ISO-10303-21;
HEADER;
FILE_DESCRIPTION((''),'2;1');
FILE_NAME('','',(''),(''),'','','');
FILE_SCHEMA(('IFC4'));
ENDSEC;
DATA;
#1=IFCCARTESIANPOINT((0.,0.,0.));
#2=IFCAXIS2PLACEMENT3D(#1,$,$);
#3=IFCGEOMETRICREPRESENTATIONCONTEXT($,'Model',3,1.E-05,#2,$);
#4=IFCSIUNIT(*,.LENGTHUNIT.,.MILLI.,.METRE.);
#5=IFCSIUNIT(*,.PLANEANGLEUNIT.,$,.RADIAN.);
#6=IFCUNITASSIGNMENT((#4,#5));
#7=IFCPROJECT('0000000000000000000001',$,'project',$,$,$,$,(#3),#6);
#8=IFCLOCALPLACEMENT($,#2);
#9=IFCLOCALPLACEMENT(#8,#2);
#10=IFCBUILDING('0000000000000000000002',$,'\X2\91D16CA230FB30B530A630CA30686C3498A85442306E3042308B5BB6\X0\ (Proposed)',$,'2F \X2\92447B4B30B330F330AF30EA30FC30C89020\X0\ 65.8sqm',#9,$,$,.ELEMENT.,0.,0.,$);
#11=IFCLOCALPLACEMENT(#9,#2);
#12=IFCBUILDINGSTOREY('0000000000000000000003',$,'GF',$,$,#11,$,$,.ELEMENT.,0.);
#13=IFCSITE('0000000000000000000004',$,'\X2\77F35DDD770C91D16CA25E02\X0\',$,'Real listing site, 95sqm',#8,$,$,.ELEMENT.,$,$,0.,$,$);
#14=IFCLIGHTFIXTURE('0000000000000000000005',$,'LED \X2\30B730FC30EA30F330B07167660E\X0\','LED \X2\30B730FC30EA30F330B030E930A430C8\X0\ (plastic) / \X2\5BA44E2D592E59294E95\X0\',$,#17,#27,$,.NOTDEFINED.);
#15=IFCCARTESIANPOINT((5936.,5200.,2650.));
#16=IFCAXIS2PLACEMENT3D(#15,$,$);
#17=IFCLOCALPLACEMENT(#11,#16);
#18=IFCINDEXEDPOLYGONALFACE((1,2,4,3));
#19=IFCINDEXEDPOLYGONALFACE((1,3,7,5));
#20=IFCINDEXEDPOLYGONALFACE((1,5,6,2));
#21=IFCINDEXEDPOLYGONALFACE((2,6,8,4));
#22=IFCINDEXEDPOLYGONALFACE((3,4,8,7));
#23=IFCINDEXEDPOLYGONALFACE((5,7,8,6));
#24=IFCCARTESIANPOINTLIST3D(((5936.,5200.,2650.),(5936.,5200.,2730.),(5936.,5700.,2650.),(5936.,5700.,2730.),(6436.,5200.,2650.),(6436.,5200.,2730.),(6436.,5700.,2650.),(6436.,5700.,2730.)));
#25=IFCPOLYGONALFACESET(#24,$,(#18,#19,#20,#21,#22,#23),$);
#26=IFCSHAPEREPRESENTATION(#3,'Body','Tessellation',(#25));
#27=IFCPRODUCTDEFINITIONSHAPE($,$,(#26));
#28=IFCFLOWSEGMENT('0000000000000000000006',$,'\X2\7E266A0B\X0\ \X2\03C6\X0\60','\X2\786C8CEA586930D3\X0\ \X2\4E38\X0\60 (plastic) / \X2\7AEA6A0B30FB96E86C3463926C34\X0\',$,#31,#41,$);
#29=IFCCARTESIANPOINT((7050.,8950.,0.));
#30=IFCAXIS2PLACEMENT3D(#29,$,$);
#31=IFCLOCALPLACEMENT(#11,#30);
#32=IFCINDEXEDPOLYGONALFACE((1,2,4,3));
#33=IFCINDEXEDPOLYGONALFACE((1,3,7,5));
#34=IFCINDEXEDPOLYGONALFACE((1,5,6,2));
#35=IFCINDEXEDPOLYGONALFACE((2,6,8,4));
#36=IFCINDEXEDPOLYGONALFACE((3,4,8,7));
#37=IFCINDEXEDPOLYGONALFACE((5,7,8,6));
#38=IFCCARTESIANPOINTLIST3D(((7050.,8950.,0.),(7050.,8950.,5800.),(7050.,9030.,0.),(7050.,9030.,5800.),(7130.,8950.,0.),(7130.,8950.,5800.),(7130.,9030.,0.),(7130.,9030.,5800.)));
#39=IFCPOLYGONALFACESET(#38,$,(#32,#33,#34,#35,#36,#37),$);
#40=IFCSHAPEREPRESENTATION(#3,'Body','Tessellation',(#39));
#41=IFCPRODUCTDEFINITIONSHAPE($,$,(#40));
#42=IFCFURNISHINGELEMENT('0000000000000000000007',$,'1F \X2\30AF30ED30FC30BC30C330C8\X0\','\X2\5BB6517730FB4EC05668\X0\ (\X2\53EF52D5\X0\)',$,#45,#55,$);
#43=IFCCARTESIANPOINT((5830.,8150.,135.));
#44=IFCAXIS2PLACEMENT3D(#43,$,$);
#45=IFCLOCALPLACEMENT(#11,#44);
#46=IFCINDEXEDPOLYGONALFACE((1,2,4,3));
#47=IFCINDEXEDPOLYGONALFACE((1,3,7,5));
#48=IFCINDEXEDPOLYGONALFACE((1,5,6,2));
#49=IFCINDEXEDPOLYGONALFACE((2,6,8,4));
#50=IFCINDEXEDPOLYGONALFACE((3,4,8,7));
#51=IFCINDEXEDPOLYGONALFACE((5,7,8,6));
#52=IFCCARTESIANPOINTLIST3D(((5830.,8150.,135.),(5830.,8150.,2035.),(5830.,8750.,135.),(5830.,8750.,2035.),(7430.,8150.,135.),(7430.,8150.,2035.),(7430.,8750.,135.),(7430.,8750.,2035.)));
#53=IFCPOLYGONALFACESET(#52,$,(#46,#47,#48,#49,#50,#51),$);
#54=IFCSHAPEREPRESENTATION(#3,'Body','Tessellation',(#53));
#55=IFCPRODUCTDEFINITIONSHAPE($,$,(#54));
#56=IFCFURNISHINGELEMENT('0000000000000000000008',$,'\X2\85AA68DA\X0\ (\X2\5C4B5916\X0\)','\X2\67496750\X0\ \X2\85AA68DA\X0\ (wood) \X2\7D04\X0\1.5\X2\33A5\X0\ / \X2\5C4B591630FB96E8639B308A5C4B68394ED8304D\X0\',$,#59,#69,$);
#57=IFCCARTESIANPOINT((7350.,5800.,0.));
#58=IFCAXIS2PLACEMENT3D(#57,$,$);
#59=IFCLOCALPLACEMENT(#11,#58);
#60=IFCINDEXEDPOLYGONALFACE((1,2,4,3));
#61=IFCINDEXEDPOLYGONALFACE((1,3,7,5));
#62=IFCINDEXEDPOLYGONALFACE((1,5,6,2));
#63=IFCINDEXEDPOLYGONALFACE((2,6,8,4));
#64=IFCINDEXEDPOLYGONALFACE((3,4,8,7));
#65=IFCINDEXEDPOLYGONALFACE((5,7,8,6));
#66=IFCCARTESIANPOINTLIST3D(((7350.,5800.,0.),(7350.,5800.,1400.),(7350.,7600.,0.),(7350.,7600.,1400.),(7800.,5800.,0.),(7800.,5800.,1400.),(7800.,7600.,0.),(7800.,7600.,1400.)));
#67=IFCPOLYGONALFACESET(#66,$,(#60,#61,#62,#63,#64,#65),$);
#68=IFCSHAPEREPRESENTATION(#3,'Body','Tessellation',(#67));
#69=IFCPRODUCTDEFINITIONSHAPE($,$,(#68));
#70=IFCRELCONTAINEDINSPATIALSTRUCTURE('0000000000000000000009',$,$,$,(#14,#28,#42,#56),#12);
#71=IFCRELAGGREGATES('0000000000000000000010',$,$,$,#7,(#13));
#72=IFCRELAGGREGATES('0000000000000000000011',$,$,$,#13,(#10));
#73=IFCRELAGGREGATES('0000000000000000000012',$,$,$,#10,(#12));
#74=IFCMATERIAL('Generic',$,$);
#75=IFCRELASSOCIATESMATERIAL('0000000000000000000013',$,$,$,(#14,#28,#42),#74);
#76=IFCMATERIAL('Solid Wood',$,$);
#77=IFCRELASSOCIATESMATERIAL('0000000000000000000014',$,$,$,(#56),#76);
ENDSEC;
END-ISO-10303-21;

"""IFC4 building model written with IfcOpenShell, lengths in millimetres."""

from ifc_helpers import new_model, si_unit, frame, frame_2d, origin, place, context, project, spatial, rectangle, extrude, material, element, save


model = new_model("IFC4")

# Units and contexts
model_context = context("Model", 3, precision=1e-05, world=origin())
ifc_project = project(units=[si_unit("LENGTHUNIT", "METRE", prefix="MILLI"), si_unit("PLANEANGLEUNIT", "RADIAN")], contexts=[model_context])

# Site, building, storey
site_placement = place(None, origin())
site = spatial("IfcSite", under=ifc_project, at=site_placement, Name="石川県金沢市", ObjectType="Real listing site, 95sqm", CompositionType="ELEMENT", RefElevation=0.0)
building_placement = place(site_placement, origin())
building = spatial("IfcBuilding", under=site, at=building_placement, Name="金沢・サウナと水風呂のある家 (Proposed)", ObjectType="2F 鉄筋コンクリート造 65.8sqm", CompositionType="ELEMENT", ElevationOfRefHeight=0.0, ElevationOfTerrain=0.0)
storey_placement = place(building_placement, origin())
storey = spatial("IfcBuildingStorey", under=building, at=storey_placement, Name="GF", CompositionType="ELEMENT", Elevation=0.0)

# Shared definitions
ifc_material_1 = material(Name="Solid Wood")

# Shared definitions
ifc_material_2 = material(Name="Generic")

# Light fixture
light_fixture_placement = place(storey_placement, frame((5936.0, 5200.0, 2650.0)))
element("IfcLightFixture", 1, at=light_fixture_placement, inside=storey, material=ifc_material_2, Name="LED シーリング照明", Description="LED シーリングライト (plastic) / 室中央天井", PredefinedType="NOTDEFINED", context=model_context, shape_type="SweptSolid", body=[
    extrude(rectangle(XDim=500.0, YDim=500.0, at=frame_2d((250.0, 250.0))), frame((5936.0, 5200.0, 2650.0)), (0.0, 0.0, 1.0), 80.0),
])

# Flow segment
flow_segment_placement = place(storey_placement, frame((7050.0, 8950.0, 0.0)))
element("IfcFlowSegment", 2, at=flow_segment_placement, inside=storey, material=ifc_material_2, Name="縦樋 φ60", Description="硬質塩ビ 丸60 (plastic) / 竪樋・雨水排水", context=model_context, shape_type="SweptSolid", body=[
    extrude(rectangle(XDim=80.0, YDim=80.0, at=frame_2d((40.0, 40.0))), frame((7050.0, 8950.0, 0.0)), (0.0, 0.0, 1.0), 5800.0),
])

# Furnishing elements
furnishing_1_placement = place(storey_placement, frame((5830.0, 8150.0, 135.0)))
element("IfcFurnishingElement", 3, at=furnishing_1_placement, inside=storey, material=ifc_material_2, Name="1F クローゼット", Description="家具・什器 (可動)", context=model_context, shape_type="SweptSolid", body=[
    extrude(rectangle(XDim=1600.0, YDim=600.0, at=frame_2d((800.0, 300.0))), frame((5830.0, 8150.0, 135.0)), (0.0, 0.0, 1.0), 1900.0),
])
furnishing_2_placement = place(storey_placement, frame((7350.0, 5800.0, 0.0)))
element("IfcFurnishingElement", 4, at=furnishing_2_placement, inside=storey, material=ifc_material_1, Name="薪棚 (屋外)", Description="杉材 薪棚 (wood) 約1.5㎥ / 屋外・雨掛り屋根付き", context=model_context, shape_type="SweptSolid", body=[
    extrude(rectangle(XDim=450.0, YDim=1800.0, at=frame_2d((225.0, 900.0))), frame((7350.0, 5800.0, 0.0)), (0.0, 0.0, 1.0), 1400.0),
])

save(model, "model.ifc")
